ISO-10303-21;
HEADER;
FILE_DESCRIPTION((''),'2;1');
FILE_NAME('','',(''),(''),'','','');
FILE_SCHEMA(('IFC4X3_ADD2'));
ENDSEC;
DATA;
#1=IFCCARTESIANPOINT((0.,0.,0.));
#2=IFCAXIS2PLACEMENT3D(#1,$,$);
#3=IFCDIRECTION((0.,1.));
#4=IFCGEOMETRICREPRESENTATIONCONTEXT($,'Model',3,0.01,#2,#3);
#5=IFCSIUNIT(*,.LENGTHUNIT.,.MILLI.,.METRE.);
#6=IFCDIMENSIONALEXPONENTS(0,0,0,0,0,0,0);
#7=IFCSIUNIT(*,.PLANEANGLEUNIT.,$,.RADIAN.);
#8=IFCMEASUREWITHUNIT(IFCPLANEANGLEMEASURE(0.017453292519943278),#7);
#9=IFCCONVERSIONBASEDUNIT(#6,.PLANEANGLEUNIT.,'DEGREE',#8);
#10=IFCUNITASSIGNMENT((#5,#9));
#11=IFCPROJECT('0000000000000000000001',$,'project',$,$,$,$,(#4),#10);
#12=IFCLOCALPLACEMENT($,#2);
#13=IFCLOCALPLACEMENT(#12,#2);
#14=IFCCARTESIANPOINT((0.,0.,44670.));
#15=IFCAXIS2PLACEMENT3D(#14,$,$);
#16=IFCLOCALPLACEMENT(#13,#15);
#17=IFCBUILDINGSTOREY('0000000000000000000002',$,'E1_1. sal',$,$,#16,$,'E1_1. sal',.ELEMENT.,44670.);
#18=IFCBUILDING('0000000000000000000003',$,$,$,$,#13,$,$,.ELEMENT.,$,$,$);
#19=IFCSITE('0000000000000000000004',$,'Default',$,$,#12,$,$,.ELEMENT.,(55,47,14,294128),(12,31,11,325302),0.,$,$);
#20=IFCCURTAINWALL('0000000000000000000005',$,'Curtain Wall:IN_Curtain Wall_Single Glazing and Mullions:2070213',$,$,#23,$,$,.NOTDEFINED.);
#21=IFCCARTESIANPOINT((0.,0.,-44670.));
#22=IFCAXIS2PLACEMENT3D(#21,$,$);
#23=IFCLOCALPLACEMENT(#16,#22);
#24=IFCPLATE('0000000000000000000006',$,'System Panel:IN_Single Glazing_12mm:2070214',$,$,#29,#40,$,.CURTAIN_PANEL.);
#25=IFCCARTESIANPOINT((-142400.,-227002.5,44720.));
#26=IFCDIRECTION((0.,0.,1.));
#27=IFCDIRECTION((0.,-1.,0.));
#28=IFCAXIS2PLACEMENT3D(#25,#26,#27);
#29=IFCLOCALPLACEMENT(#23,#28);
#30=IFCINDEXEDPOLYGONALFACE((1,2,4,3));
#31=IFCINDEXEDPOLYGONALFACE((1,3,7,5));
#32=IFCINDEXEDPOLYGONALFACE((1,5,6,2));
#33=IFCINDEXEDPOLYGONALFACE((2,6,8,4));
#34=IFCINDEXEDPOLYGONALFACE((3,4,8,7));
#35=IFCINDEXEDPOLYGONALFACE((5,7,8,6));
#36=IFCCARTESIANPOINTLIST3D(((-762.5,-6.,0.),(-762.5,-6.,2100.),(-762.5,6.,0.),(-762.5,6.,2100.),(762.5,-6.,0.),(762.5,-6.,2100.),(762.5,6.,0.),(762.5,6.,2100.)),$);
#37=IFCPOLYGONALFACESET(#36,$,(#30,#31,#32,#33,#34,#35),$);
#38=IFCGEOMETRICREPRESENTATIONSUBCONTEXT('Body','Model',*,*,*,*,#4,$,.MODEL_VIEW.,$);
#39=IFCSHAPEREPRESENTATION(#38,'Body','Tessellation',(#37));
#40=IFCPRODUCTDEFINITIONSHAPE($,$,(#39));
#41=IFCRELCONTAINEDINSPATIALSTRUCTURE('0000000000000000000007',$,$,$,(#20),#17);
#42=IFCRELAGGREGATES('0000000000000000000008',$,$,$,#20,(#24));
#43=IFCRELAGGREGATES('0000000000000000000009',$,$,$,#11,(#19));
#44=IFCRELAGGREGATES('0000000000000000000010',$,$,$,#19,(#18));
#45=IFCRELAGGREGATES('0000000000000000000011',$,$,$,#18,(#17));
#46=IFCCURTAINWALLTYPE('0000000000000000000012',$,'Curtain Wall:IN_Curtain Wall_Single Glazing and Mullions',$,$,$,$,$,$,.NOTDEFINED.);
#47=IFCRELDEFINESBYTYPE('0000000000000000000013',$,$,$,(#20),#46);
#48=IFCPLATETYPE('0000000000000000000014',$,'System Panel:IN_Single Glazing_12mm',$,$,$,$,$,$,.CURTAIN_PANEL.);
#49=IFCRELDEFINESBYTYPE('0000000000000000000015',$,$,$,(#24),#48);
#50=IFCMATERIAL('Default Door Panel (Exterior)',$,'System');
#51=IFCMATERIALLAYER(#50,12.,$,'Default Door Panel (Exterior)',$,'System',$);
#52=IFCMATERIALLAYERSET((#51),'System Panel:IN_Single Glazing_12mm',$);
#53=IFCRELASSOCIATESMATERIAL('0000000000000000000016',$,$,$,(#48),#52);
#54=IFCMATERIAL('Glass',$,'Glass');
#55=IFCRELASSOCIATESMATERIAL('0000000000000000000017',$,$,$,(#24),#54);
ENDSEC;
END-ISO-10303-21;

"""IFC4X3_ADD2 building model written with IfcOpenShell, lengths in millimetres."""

from ifc_helpers import new_model, entity, si_unit, converted_unit, direction, frame, origin, origin_2d_with_axis, place, context, subcontext, project, spatial, rectangle, extrude, source, transform, mapped, material, layer, layer_set, type_object, type_shapes, element, aggregate, save


model = new_model("IFC4X3_ADD2")

# Units and contexts
model_context = context("Model", 3, precision=0.01, world=origin(), true_north=direction((0.0, 1.0)))
body_context = subcontext(model_context, "Body", "Model", "MODEL_VIEW")
ifc_project = project(units=[si_unit("LENGTHUNIT", "METRE", prefix="MILLI"), converted_unit("PLANEANGLEUNIT", "DEGREE", entity("IfcPlaneAngleMeasure", 0.017453292519943278), si_unit("PLANEANGLEUNIT", "RADIAN"), dimensions=[0, 0, 0, 0, 0, 0, 0])], contexts=[model_context])

# Site, building, storey
site_placement = place(None, origin())
site = spatial("IfcSite", under=ifc_project, at=site_placement, Name="Default", CompositionType="ELEMENT", RefLatitude=(55, 47, 14, 294128), RefLongitude=(12, 31, 11, 325302), RefElevation=0.0)
building_placement = place(site_placement, origin())
building = spatial("IfcBuilding", under=site, at=building_placement, CompositionType="ELEMENT")
storey_placement = place(building_placement, frame((0.0, 0.0, 44670.0)))
storey = spatial("IfcBuildingStorey", under=building, at=storey_placement, Name="E1_1. sal", LongName="E1_1. sal", CompositionType="ELEMENT", Elevation=44670.0)

# Curtain wall
curtain_wall_type_1 = type_object("IfcCurtainWallType", Name="Curtain Wall:IN_Curtain Wall_Single Glazing and Mullions", PredefinedType="NOTDEFINED")
curtain_wall_1_placement = place(storey_placement, frame((0.0, 0.0, -44670.0)))
curtain_wall_1 = element("IfcCurtainWall", 1, at=curtain_wall_1_placement, inside=storey, type_object=curtain_wall_type_1, Name="Curtain Wall:IN_Curtain Wall_Single Glazing and Mullions:2070213", PredefinedType="NOTDEFINED")

# Plate
ifc_material_1 = material(Name="Default Door Panel (Exterior)", Category="System")
ifc_material_2 = material(Name="Glass", Category="Glass")
ifc_layer_1 = layer(ifc_material_1, 12.0, Name="Default Door Panel (Exterior)", Category="System")
ifc_layer_set_1 = layer_set([ifc_layer_1], Name="System Panel:IN_Single Glazing_12mm")
plate_type_1 = type_object("IfcPlateType", Name="System Panel:IN_Single Glazing_12mm", PredefinedType="CURTAIN_PANEL", material=ifc_layer_set_1)
shared_shape_1 = source(origin(), body_context, "Body", "SweptSolid", [
    extrude(rectangle(XDim=12.0, YDim=1525.0, at=origin_2d_with_axis()), frame((0.0, 0.0, 0.0), z_axis=(0.0, 0.0, 1.0), x_axis=(0.0, 1.0, 0.0)), (0.0, 0.0, 1.0), 2100.0),
])
type_shapes(plate_type_1, [shared_shape_1])
plate_1_placement = place(curtain_wall_1_placement, frame((-142400.0, -227002.5, 44720.0), z_axis=(0.0, 0.0, 1.0), x_axis=(0.0, -1.0, 0.0)))
plate_1 = element("IfcPlate", 2, at=plate_1_placement, type_object=plate_type_1, material=ifc_material_2, Name="System Panel:IN_Single Glazing_12mm:2070214", PredefinedType="CURTAIN_PANEL", context=body_context, shape_type="MappedRepresentation", body=[
    mapped(shared_shape_1, transform((0.0, 0.0, 0.0), scale=1.0)),
])
aggregate(curtain_wall_1, [plate_1])

save(model, "model.ifc")
